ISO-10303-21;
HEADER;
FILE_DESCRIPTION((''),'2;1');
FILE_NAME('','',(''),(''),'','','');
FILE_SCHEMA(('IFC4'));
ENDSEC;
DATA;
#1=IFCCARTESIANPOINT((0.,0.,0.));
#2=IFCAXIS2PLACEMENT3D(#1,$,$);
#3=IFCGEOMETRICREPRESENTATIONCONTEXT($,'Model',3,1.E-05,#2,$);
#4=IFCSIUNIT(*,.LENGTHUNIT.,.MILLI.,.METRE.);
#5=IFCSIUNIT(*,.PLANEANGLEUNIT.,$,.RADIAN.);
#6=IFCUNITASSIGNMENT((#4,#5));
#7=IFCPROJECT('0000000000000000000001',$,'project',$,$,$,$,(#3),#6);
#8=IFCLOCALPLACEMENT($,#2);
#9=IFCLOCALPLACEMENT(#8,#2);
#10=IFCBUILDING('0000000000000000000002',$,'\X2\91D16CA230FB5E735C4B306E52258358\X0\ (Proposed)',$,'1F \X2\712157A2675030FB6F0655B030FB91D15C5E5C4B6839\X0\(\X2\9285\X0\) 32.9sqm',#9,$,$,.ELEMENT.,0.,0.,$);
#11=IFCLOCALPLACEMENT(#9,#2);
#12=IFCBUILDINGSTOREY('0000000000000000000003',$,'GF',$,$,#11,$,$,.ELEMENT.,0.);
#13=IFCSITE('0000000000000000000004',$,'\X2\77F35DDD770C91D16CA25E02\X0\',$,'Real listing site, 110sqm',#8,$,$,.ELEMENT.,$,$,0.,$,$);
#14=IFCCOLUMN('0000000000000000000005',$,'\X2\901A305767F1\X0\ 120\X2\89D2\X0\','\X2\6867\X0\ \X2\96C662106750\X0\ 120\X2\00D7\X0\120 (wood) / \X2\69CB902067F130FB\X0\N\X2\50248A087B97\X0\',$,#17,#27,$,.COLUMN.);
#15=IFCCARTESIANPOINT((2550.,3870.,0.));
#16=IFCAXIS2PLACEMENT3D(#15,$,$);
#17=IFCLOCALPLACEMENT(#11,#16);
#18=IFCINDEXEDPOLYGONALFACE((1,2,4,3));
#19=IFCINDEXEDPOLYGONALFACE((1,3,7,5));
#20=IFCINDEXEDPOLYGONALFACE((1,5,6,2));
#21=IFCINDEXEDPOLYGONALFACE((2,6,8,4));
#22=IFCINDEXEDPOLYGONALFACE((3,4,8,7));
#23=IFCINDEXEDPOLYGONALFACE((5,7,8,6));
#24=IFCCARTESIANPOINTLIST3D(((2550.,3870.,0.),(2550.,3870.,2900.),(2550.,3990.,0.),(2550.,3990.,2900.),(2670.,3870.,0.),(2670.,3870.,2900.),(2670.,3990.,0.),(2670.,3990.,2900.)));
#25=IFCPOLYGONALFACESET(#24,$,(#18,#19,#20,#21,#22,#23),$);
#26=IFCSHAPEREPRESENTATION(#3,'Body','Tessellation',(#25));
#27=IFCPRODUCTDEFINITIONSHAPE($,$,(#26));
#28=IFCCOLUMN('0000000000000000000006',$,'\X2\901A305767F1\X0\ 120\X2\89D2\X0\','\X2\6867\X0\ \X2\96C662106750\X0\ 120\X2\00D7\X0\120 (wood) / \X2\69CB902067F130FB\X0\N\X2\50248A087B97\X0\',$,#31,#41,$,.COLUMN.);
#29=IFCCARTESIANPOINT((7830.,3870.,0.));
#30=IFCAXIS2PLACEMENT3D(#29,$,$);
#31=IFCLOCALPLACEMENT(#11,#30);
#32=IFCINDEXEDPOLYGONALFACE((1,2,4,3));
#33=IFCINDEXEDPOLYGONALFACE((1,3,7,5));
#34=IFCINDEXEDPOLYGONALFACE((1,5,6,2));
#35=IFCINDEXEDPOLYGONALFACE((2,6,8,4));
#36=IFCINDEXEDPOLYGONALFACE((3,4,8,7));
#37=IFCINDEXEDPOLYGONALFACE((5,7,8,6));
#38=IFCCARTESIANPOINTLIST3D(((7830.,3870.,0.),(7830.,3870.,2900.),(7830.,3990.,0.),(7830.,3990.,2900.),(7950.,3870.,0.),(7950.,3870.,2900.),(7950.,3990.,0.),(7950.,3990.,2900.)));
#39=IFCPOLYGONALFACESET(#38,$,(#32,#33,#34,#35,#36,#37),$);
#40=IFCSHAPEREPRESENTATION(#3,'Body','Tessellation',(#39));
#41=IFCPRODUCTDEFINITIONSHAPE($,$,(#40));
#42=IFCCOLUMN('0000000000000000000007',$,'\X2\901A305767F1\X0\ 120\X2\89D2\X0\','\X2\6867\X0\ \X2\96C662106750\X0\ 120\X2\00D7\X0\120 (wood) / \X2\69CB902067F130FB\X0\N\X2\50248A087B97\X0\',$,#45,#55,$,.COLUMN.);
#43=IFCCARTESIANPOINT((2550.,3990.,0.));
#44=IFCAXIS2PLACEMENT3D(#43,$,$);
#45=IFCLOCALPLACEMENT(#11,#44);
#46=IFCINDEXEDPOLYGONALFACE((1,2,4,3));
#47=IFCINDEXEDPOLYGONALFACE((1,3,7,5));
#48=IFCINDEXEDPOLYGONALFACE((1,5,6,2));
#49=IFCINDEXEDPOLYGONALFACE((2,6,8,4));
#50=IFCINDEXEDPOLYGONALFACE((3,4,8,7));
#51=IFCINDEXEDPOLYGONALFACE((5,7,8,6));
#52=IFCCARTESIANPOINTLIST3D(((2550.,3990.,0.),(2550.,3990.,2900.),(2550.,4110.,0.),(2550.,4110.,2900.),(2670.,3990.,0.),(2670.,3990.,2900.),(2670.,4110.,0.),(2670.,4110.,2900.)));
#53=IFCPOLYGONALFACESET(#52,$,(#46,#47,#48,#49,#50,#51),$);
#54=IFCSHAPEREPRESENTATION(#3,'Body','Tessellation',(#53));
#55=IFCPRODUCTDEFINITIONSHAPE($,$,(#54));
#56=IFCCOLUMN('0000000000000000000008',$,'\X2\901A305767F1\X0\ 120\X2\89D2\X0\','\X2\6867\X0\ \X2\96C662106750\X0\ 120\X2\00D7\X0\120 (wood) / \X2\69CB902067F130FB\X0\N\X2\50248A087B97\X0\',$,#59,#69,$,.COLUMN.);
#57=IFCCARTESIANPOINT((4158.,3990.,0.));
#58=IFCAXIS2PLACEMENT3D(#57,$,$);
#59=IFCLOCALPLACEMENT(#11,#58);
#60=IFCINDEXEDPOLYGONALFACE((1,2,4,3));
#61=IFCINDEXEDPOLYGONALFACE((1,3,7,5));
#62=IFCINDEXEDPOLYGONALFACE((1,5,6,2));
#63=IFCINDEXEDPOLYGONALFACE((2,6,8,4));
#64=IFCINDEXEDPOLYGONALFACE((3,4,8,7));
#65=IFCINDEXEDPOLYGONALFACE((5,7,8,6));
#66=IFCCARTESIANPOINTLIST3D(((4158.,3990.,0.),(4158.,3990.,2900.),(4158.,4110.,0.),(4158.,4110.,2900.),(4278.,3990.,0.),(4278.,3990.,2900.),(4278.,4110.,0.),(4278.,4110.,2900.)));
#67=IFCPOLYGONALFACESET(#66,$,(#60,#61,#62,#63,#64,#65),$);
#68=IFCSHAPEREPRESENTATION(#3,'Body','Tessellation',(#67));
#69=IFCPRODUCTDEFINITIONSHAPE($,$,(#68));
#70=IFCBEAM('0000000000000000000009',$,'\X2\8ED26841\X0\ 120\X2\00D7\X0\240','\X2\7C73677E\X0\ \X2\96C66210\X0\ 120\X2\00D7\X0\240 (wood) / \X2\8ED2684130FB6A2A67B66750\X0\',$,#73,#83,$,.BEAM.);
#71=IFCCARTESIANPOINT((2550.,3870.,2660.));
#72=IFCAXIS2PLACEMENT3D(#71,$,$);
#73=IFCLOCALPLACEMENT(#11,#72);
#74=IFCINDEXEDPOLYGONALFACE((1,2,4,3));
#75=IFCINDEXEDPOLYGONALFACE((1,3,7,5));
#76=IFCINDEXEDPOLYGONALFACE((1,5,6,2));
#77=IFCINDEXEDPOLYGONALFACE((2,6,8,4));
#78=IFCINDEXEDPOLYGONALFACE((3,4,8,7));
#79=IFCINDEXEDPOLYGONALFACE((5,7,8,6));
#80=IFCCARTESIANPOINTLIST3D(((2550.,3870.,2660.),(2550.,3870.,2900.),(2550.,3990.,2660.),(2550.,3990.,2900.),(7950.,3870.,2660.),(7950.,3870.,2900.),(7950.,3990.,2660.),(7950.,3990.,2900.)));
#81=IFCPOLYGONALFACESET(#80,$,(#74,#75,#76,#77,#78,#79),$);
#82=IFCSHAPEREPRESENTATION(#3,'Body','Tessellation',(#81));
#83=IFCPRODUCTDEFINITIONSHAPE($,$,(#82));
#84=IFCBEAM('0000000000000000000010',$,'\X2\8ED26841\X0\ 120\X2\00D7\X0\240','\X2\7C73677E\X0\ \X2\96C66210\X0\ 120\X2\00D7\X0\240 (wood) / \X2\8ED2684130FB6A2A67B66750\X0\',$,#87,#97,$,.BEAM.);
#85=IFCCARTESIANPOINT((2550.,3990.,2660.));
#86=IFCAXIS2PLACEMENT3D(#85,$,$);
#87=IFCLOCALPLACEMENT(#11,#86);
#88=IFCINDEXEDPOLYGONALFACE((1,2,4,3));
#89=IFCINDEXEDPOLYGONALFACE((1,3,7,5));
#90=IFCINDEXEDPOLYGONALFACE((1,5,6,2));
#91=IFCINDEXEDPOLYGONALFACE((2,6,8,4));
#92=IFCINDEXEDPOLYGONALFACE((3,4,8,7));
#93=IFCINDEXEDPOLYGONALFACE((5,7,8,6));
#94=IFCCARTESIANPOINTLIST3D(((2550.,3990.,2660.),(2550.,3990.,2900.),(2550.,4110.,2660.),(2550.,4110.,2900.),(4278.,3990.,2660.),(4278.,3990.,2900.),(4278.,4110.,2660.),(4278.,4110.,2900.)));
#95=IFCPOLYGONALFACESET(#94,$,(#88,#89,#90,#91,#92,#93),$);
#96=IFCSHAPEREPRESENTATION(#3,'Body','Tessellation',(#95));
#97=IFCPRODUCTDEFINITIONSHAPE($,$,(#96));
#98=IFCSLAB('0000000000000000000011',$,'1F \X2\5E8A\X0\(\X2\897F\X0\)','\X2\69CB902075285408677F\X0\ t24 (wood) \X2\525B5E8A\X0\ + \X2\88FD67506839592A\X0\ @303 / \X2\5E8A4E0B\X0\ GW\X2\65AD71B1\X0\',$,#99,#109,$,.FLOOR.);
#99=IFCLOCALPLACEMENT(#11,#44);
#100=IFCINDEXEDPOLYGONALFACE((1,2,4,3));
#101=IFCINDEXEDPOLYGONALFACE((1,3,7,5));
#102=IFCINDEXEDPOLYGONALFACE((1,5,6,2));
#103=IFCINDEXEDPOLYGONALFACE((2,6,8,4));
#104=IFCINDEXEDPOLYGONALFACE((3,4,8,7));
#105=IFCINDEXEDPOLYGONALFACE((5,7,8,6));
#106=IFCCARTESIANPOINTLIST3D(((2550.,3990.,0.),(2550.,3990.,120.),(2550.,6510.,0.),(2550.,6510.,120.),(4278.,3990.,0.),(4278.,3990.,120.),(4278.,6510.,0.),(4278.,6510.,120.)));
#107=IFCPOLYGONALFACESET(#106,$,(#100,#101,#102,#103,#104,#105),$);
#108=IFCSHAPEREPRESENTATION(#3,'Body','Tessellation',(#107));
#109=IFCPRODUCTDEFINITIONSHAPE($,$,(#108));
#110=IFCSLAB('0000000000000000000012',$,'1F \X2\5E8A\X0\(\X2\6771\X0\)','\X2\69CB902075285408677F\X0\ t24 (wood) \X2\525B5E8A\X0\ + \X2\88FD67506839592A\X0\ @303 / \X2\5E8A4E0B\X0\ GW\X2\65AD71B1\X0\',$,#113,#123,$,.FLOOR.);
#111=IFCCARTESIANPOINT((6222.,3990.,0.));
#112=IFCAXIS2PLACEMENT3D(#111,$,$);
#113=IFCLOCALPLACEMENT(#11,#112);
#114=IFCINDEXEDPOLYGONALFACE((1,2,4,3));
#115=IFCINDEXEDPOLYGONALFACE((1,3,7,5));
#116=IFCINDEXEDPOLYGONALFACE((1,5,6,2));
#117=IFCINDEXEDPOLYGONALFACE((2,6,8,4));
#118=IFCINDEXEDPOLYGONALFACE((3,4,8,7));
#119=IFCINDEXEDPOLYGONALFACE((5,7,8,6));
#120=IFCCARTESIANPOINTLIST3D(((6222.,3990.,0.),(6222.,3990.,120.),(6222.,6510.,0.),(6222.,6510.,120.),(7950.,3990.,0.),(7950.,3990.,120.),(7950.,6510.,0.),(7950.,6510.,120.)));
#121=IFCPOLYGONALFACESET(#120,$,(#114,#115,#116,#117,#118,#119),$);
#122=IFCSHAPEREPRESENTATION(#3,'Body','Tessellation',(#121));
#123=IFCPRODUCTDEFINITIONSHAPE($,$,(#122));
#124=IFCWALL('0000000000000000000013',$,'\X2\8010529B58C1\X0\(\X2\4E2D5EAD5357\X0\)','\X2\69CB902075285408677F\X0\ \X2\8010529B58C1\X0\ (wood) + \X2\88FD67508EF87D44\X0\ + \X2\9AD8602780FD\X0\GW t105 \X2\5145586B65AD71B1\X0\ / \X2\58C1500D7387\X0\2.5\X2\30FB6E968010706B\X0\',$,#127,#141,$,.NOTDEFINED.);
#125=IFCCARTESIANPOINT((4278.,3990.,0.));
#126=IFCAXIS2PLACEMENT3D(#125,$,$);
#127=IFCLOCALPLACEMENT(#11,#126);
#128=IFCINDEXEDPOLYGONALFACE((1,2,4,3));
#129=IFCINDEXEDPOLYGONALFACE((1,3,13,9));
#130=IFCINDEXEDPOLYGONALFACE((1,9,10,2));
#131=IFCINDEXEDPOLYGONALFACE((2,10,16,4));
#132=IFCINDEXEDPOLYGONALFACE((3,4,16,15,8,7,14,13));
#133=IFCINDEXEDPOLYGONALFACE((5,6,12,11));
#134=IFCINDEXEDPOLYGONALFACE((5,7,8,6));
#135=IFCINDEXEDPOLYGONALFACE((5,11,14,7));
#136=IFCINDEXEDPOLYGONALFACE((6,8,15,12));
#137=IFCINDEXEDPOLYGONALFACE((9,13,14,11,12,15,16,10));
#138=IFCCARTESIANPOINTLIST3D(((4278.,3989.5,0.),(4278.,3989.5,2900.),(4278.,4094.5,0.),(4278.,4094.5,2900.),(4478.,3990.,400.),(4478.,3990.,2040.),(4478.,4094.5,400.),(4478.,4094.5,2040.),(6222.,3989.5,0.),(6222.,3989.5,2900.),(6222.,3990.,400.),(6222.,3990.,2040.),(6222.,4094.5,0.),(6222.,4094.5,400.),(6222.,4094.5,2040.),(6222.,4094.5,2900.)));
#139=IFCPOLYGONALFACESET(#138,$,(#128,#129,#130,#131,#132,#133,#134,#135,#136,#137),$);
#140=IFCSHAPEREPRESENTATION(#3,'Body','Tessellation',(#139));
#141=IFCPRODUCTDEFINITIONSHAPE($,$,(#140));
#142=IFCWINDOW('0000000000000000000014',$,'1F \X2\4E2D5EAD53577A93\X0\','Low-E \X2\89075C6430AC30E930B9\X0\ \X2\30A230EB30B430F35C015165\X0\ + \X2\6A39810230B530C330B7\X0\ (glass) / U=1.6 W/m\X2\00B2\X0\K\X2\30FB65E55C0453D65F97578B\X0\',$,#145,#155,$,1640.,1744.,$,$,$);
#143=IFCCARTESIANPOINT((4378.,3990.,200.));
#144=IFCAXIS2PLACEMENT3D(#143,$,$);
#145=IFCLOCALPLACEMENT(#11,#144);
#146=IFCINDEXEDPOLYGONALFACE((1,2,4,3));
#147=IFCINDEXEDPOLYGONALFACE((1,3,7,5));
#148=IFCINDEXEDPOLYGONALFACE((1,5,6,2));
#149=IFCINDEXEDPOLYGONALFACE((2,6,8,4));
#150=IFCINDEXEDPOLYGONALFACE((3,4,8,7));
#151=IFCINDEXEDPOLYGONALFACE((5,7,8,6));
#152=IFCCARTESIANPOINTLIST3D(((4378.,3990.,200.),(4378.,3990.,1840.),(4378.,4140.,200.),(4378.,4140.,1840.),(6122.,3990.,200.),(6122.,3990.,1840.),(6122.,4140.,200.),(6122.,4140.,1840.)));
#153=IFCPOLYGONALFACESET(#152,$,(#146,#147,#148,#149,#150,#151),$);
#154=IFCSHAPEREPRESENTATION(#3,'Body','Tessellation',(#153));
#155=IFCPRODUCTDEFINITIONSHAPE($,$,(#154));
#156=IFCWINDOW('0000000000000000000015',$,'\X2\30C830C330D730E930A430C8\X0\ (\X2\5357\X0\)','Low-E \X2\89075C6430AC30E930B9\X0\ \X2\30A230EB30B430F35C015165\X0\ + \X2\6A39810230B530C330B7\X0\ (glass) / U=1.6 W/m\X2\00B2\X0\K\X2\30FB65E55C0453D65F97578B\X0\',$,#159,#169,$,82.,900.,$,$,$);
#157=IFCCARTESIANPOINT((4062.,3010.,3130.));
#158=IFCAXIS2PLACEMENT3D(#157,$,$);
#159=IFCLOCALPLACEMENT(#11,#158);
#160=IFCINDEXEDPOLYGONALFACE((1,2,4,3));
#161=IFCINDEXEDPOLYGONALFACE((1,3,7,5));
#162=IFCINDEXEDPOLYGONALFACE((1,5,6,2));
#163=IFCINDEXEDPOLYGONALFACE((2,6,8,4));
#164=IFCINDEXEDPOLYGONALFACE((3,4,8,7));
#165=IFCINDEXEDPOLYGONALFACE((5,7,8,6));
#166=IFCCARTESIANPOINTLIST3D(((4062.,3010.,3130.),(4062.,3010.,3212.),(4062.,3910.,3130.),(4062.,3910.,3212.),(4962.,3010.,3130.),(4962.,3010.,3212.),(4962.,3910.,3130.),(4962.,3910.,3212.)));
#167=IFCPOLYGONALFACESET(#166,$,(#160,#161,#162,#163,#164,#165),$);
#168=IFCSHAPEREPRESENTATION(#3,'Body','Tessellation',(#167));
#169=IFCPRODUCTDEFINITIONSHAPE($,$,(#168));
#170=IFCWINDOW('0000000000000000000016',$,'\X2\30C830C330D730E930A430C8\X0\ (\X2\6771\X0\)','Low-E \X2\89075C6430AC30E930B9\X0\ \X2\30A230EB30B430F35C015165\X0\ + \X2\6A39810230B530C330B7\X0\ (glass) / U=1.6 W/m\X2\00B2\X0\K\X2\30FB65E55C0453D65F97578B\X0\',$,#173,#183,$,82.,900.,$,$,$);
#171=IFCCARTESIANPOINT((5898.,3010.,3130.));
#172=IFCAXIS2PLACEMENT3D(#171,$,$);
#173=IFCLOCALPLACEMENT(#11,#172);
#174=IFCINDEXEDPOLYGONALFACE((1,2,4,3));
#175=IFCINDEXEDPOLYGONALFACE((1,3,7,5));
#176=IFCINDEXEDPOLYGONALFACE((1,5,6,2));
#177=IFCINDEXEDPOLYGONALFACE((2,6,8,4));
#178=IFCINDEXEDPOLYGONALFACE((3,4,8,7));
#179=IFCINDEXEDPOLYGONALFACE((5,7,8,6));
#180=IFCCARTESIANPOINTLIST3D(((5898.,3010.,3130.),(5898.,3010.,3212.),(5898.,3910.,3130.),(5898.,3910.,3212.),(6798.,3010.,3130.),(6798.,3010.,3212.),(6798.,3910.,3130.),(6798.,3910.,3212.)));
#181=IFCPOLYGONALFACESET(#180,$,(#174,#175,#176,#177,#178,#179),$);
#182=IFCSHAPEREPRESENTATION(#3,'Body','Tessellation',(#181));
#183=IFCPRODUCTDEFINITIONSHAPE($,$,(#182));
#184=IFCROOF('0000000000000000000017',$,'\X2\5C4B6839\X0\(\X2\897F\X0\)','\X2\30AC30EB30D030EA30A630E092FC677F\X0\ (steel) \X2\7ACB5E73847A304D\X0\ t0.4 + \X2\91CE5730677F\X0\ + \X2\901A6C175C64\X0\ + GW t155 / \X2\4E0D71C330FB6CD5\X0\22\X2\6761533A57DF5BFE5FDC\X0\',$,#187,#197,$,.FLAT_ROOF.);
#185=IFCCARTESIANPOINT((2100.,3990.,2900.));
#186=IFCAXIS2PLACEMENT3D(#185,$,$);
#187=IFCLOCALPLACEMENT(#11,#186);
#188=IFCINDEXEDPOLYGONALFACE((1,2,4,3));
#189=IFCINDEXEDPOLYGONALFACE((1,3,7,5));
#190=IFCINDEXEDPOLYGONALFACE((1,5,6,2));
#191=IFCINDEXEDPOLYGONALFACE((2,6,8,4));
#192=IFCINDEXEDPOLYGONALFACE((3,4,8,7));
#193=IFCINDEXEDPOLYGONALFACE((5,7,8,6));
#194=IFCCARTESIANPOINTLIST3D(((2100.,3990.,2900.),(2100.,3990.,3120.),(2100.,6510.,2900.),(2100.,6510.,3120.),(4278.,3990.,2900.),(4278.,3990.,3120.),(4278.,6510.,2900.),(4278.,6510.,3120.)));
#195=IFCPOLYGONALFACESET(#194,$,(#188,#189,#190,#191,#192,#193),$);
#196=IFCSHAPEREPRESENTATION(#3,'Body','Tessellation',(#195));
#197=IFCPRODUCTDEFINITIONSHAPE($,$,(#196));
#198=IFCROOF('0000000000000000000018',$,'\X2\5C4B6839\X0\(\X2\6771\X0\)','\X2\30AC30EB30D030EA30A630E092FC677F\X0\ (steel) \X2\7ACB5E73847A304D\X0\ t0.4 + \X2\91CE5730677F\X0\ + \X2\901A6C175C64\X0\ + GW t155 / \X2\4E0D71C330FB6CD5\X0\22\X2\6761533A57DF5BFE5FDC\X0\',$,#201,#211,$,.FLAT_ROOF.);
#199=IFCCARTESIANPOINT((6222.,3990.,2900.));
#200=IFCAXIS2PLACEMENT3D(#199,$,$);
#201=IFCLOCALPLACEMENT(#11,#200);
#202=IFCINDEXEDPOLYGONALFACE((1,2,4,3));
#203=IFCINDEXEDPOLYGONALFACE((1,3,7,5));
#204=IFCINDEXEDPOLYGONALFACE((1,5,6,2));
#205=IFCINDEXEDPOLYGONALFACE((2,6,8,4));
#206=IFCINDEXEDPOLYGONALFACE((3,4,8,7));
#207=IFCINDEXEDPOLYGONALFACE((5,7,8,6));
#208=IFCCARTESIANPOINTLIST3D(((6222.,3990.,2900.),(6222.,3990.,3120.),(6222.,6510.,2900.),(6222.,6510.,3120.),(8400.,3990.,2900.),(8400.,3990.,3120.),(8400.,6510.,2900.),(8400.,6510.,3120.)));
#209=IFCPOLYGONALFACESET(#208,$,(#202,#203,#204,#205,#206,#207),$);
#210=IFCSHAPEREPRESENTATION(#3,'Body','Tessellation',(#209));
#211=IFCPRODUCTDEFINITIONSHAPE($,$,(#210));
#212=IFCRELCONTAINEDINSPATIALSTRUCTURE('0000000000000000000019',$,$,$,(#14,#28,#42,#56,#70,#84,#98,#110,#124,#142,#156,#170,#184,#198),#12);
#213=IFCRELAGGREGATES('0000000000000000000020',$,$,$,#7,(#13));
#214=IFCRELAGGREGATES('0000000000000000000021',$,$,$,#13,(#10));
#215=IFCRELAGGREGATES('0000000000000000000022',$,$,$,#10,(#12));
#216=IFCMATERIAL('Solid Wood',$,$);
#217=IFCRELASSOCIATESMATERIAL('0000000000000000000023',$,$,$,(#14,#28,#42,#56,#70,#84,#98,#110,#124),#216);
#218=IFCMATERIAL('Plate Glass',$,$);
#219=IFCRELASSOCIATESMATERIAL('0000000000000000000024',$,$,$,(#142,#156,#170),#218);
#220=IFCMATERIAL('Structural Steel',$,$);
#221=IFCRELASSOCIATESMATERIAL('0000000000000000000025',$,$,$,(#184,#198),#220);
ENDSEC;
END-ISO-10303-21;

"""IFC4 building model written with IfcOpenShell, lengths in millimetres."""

from ifc_helpers import new_model, si_unit, frame, frame_2d, origin, place, context, project, spatial, rectangle, extrude, material, element, fill, save


model = new_model("IFC4")

# Units and contexts
model_context = context("Model", 3, precision=1e-05, world=origin())
ifc_project = project(units=[si_unit("LENGTHUNIT", "METRE", prefix="MILLI"), si_unit("PLANEANGLEUNIT", "RADIAN")], contexts=[model_context])

# Site, building, storey
site_placement = place(None, origin())
site = spatial("IfcSite", under=ifc_project, at=site_placement, Name="石川県金沢市", ObjectType="Real listing site, 110sqm", CompositionType="ELEMENT", RefElevation=0.0)
building_placement = place(site_placement, origin())
building = spatial("IfcBuilding", under=site, at=building_placement, Name="金沢・平屋の別荘 (Proposed)", ObjectType="1F 無垢材・漆喰・金属屋根(銅) 32.9sqm", CompositionType="ELEMENT", ElevationOfRefHeight=0.0, ElevationOfTerrain=0.0)
storey_placement = place(building_placement, origin())
storey = spatial("IfcBuildingStorey", under=building, at=storey_placement, Name="GF", CompositionType="ELEMENT", Elevation=0.0)

# Columns
ifc_material_1 = material(Name="Solid Wood")
column_1_placement = place(storey_placement, frame((2550.0, 3870.0, 0.0)))
element("IfcColumn", 1, at=column_1_placement, inside=storey, material=ifc_material_1, Name="通し柱 120角", Description="桧 集成材 120×120 (wood) / 構造柱・N値計算", PredefinedType="COLUMN", context=model_context, shape_type="SweptSolid", body=[
    extrude(rectangle(XDim=120.0, YDim=120.0, at=frame_2d((60.0, 60.0))), frame((2550.0, 3870.0, 0.0)), (0.0, 0.0, 1.0), 2900.0),
])
column_2_placement = place(storey_placement, frame((7830.0, 3870.0, 0.0)))
element("IfcColumn", 2, at=column_2_placement, inside=storey, material=ifc_material_1, Name="通し柱 120角", Description="桧 集成材 120×120 (wood) / 構造柱・N値計算", PredefinedType="COLUMN", context=model_context, shape_type="SweptSolid", body=[
    extrude(rectangle(XDim=120.0, YDim=120.0, at=frame_2d((60.0, 60.0))), frame((7830.0, 3870.0, 0.0)), (0.0, 0.0, 1.0), 2900.0),
])
column_3_placement = place(storey_placement, frame((2550.0, 3990.0, 0.0)))
element("IfcColumn", 3, at=column_3_placement, inside=storey, material=ifc_material_1, Name="通し柱 120角", Description="桧 集成材 120×120 (wood) / 構造柱・N値計算", PredefinedType="COLUMN", context=model_context, shape_type="SweptSolid", body=[
    extrude(rectangle(XDim=120.0, YDim=120.0, at=frame_2d((60.0, 60.0))), frame((2550.0, 3990.0, 0.0)), (0.0, 0.0, 1.0), 2900.0),
])
column_4_placement = place(storey_placement, frame((4158.0, 3990.0, 0.0)))
element("IfcColumn", 4, at=column_4_placement, inside=storey, material=ifc_material_1, Name="通し柱 120角", Description="桧 集成材 120×120 (wood) / 構造柱・N値計算", PredefinedType="COLUMN", context=model_context, shape_type="SweptSolid", body=[
    extrude(rectangle(XDim=120.0, YDim=120.0, at=frame_2d((60.0, 60.0))), frame((4158.0, 3990.0, 0.0)), (0.0, 0.0, 1.0), 2900.0),
])

# Beams
beam_1_placement = place(storey_placement, frame((2550.0, 3870.0, 2660.0)))
element("IfcBeam", 5, at=beam_1_placement, inside=storey, material=ifc_material_1, Name="軒桁 120×240", Description="米松 集成 120×240 (wood) / 軒桁・横架材", PredefinedType="BEAM", context=model_context, shape_type="SweptSolid", body=[
    extrude(rectangle(XDim=5400.0, YDim=120.0, at=frame_2d((2700.0, 60.0))), frame((2550.0, 3870.0, 2660.0)), (0.0, 0.0, 1.0), 240.0),
])
beam_2_placement = place(storey_placement, frame((2550.0, 3990.0, 2660.0)))
element("IfcBeam", 6, at=beam_2_placement, inside=storey, material=ifc_material_1, Name="軒桁 120×240", Description="米松 集成 120×240 (wood) / 軒桁・横架材", PredefinedType="BEAM", context=model_context, shape_type="SweptSolid", body=[
    extrude(rectangle(XDim=1728.0, YDim=120.0, at=frame_2d((864.0, 60.0))), frame((2550.0, 3990.0, 2660.0)), (0.0, 0.0, 1.0), 240.0),
])

# Slabs
slab_1_placement = place(storey_placement, frame((2550.0, 3990.0, 0.0)))
element("IfcSlab", 7, at=slab_1_placement, inside=storey, material=ifc_material_1, Name="1F 床(西)", Description="構造用合板 t24 (wood) 剛床 + 製材根太 @303 / 床下 GW断熱", PredefinedType="FLOOR", context=model_context, shape_type="SweptSolid", body=[
    extrude(rectangle(XDim=1728.0, YDim=2520.0, at=frame_2d((864.0, 1260.0))), frame((2550.0, 3990.0, 0.0)), (0.0, 0.0, 1.0), 120.0),
])
slab_2_placement = place(storey_placement, frame((6222.0, 3990.0, 0.0)))
element("IfcSlab", 8, at=slab_2_placement, inside=storey, material=ifc_material_1, Name="1F 床(東)", Description="構造用合板 t24 (wood) 剛床 + 製材根太 @303 / 床下 GW断熱", PredefinedType="FLOOR", context=model_context, shape_type="SweptSolid", body=[
    extrude(rectangle(XDim=1728.0, YDim=2520.0, at=frame_2d((864.0, 1260.0))), frame((6222.0, 3990.0, 0.0)), (0.0, 0.0, 1.0), 120.0),
])

# Wall, opening, window
wall_1_placement = place(storey_placement, frame((4278.0, 3990.0, 0.0)))
wall_1 = element("IfcWall", 9, at=wall_1_placement, inside=storey, material=ifc_material_1, Name="耐力壁(中庭南)", Description="構造用合板 耐力壁 (wood) + 製材軸組 + 高性能GW t105 充填断熱 / 壁倍率2.5・準耐火", PredefinedType="NOTDEFINED", context=model_context, shape_type="SweptSolid", body=[
    extrude(rectangle(XDim=1944.0, YDim=105.0, at=frame_2d((972.0, 52.0))), frame((4278.0, 3990.0, 0.0)), (0.0, 0.0, 1.0), 2900.0),
])
opening_placement = place(storey_placement, frame((4378.0, 3990.0, 200.0)))
opening = element("IfcOpeningElement", 10, at=opening_placement, cuts=wall_1, PredefinedType="NOTDEFINED", context=model_context, shape_type="SweptSolid", body=[
    extrude(rectangle(XDim=1744.0, YDim=150.0, at=frame_2d((872.0, 75.0))), frame((4378.0, 3990.0, 200.0)), (0.0, 0.0, 1.0), 1640.0),
])
ifc_material_2 = material(Name="Plate Glass")
window_1_placement = place(storey_placement, frame((4378.0, 3990.0, 200.0)))
window_1 = element("IfcWindow", 11, at=window_1_placement, inside=storey, material=ifc_material_2, Name="1F 中庭南窓", Description="Low-E 複層ガラス アルゴン封入 + 樹脂サッシ (glass) / U=1.6 W/m²K・日射取得型", OverallHeight=1640.0, OverallWidth=1744.0, context=model_context, shape_type="SweptSolid", body=[
    extrude(rectangle(XDim=1744.0, YDim=150.0, at=frame_2d((872.0, 75.0))), frame((4378.0, 3990.0, 200.0)), (0.0, 0.0, 1.0), 1640.0),
])
fill(opening, window_1)

# Windows
window_2_placement = place(storey_placement, frame((4062.0, 3010.0, 3130.0)))
element("IfcWindow", 12, at=window_2_placement, inside=storey, material=ifc_material_2, Name="トップライト (南)", Description="Low-E 複層ガラス アルゴン封入 + 樹脂サッシ (glass) / U=1.6 W/m²K・日射取得型", OverallHeight=82.0, OverallWidth=900.0, context=model_context, shape_type="SweptSolid", body=[
    extrude(rectangle(XDim=900.0, YDim=900.0, at=frame_2d((450.0, 450.0))), frame((4062.0, 3010.0, 3130.0)), (0.0, 0.0, 1.0), 82.0),
])
window_3_placement = place(storey_placement, frame((5898.0, 3010.0, 3130.0)))
element("IfcWindow", 13, at=window_3_placement, inside=storey, material=ifc_material_2, Name="トップライト (東)", Description="Low-E 複層ガラス アルゴン封入 + 樹脂サッシ (glass) / U=1.6 W/m²K・日射取得型", OverallHeight=82.0, OverallWidth=900.0, context=model_context, shape_type="SweptSolid", body=[
    extrude(rectangle(XDim=900.0, YDim=900.0, at=frame_2d((450.0, 450.0))), frame((5898.0, 3010.0, 3130.0)), (0.0, 0.0, 1.0), 82.0),
])

# Roofs
ifc_material_3 = material(Name="Structural Steel")
roof_1_placement = place(storey_placement, frame((2100.0, 3990.0, 2900.0)))
element("IfcRoof", 14, at=roof_1_placement, inside=storey, material=ifc_material_3, Name="屋根(西)", Description="ガルバリウム鋼板 (steel) 立平葺き t0.4 + 野地板 + 通気層 + GW t155 / 不燃・法22条区域対応", PredefinedType="FLAT_ROOF", context=model_context, shape_type="SweptSolid", body=[
    extrude(rectangle(XDim=2178.0, YDim=2520.0, at=frame_2d((1089.0, 1260.0))), frame((2100.0, 3990.0, 2900.0)), (0.0, 0.0, 1.0), 220.0),
])
roof_2_placement = place(storey_placement, frame((6222.0, 3990.0, 2900.0)))
element("IfcRoof", 15, at=roof_2_placement, inside=storey, material=ifc_material_3, Name="屋根(東)", Description="ガルバリウム鋼板 (steel) 立平葺き t0.4 + 野地板 + 通気層 + GW t155 / 不燃・法22条区域対応", PredefinedType="FLAT_ROOF", context=model_context, shape_type="SweptSolid", body=[
    extrude(rectangle(XDim=2178.0, YDim=2520.0, at=frame_2d((1089.0, 1260.0))), frame((6222.0, 3990.0, 2900.0)), (0.0, 0.0, 1.0), 220.0),
])

save(model, "model.ifc")
